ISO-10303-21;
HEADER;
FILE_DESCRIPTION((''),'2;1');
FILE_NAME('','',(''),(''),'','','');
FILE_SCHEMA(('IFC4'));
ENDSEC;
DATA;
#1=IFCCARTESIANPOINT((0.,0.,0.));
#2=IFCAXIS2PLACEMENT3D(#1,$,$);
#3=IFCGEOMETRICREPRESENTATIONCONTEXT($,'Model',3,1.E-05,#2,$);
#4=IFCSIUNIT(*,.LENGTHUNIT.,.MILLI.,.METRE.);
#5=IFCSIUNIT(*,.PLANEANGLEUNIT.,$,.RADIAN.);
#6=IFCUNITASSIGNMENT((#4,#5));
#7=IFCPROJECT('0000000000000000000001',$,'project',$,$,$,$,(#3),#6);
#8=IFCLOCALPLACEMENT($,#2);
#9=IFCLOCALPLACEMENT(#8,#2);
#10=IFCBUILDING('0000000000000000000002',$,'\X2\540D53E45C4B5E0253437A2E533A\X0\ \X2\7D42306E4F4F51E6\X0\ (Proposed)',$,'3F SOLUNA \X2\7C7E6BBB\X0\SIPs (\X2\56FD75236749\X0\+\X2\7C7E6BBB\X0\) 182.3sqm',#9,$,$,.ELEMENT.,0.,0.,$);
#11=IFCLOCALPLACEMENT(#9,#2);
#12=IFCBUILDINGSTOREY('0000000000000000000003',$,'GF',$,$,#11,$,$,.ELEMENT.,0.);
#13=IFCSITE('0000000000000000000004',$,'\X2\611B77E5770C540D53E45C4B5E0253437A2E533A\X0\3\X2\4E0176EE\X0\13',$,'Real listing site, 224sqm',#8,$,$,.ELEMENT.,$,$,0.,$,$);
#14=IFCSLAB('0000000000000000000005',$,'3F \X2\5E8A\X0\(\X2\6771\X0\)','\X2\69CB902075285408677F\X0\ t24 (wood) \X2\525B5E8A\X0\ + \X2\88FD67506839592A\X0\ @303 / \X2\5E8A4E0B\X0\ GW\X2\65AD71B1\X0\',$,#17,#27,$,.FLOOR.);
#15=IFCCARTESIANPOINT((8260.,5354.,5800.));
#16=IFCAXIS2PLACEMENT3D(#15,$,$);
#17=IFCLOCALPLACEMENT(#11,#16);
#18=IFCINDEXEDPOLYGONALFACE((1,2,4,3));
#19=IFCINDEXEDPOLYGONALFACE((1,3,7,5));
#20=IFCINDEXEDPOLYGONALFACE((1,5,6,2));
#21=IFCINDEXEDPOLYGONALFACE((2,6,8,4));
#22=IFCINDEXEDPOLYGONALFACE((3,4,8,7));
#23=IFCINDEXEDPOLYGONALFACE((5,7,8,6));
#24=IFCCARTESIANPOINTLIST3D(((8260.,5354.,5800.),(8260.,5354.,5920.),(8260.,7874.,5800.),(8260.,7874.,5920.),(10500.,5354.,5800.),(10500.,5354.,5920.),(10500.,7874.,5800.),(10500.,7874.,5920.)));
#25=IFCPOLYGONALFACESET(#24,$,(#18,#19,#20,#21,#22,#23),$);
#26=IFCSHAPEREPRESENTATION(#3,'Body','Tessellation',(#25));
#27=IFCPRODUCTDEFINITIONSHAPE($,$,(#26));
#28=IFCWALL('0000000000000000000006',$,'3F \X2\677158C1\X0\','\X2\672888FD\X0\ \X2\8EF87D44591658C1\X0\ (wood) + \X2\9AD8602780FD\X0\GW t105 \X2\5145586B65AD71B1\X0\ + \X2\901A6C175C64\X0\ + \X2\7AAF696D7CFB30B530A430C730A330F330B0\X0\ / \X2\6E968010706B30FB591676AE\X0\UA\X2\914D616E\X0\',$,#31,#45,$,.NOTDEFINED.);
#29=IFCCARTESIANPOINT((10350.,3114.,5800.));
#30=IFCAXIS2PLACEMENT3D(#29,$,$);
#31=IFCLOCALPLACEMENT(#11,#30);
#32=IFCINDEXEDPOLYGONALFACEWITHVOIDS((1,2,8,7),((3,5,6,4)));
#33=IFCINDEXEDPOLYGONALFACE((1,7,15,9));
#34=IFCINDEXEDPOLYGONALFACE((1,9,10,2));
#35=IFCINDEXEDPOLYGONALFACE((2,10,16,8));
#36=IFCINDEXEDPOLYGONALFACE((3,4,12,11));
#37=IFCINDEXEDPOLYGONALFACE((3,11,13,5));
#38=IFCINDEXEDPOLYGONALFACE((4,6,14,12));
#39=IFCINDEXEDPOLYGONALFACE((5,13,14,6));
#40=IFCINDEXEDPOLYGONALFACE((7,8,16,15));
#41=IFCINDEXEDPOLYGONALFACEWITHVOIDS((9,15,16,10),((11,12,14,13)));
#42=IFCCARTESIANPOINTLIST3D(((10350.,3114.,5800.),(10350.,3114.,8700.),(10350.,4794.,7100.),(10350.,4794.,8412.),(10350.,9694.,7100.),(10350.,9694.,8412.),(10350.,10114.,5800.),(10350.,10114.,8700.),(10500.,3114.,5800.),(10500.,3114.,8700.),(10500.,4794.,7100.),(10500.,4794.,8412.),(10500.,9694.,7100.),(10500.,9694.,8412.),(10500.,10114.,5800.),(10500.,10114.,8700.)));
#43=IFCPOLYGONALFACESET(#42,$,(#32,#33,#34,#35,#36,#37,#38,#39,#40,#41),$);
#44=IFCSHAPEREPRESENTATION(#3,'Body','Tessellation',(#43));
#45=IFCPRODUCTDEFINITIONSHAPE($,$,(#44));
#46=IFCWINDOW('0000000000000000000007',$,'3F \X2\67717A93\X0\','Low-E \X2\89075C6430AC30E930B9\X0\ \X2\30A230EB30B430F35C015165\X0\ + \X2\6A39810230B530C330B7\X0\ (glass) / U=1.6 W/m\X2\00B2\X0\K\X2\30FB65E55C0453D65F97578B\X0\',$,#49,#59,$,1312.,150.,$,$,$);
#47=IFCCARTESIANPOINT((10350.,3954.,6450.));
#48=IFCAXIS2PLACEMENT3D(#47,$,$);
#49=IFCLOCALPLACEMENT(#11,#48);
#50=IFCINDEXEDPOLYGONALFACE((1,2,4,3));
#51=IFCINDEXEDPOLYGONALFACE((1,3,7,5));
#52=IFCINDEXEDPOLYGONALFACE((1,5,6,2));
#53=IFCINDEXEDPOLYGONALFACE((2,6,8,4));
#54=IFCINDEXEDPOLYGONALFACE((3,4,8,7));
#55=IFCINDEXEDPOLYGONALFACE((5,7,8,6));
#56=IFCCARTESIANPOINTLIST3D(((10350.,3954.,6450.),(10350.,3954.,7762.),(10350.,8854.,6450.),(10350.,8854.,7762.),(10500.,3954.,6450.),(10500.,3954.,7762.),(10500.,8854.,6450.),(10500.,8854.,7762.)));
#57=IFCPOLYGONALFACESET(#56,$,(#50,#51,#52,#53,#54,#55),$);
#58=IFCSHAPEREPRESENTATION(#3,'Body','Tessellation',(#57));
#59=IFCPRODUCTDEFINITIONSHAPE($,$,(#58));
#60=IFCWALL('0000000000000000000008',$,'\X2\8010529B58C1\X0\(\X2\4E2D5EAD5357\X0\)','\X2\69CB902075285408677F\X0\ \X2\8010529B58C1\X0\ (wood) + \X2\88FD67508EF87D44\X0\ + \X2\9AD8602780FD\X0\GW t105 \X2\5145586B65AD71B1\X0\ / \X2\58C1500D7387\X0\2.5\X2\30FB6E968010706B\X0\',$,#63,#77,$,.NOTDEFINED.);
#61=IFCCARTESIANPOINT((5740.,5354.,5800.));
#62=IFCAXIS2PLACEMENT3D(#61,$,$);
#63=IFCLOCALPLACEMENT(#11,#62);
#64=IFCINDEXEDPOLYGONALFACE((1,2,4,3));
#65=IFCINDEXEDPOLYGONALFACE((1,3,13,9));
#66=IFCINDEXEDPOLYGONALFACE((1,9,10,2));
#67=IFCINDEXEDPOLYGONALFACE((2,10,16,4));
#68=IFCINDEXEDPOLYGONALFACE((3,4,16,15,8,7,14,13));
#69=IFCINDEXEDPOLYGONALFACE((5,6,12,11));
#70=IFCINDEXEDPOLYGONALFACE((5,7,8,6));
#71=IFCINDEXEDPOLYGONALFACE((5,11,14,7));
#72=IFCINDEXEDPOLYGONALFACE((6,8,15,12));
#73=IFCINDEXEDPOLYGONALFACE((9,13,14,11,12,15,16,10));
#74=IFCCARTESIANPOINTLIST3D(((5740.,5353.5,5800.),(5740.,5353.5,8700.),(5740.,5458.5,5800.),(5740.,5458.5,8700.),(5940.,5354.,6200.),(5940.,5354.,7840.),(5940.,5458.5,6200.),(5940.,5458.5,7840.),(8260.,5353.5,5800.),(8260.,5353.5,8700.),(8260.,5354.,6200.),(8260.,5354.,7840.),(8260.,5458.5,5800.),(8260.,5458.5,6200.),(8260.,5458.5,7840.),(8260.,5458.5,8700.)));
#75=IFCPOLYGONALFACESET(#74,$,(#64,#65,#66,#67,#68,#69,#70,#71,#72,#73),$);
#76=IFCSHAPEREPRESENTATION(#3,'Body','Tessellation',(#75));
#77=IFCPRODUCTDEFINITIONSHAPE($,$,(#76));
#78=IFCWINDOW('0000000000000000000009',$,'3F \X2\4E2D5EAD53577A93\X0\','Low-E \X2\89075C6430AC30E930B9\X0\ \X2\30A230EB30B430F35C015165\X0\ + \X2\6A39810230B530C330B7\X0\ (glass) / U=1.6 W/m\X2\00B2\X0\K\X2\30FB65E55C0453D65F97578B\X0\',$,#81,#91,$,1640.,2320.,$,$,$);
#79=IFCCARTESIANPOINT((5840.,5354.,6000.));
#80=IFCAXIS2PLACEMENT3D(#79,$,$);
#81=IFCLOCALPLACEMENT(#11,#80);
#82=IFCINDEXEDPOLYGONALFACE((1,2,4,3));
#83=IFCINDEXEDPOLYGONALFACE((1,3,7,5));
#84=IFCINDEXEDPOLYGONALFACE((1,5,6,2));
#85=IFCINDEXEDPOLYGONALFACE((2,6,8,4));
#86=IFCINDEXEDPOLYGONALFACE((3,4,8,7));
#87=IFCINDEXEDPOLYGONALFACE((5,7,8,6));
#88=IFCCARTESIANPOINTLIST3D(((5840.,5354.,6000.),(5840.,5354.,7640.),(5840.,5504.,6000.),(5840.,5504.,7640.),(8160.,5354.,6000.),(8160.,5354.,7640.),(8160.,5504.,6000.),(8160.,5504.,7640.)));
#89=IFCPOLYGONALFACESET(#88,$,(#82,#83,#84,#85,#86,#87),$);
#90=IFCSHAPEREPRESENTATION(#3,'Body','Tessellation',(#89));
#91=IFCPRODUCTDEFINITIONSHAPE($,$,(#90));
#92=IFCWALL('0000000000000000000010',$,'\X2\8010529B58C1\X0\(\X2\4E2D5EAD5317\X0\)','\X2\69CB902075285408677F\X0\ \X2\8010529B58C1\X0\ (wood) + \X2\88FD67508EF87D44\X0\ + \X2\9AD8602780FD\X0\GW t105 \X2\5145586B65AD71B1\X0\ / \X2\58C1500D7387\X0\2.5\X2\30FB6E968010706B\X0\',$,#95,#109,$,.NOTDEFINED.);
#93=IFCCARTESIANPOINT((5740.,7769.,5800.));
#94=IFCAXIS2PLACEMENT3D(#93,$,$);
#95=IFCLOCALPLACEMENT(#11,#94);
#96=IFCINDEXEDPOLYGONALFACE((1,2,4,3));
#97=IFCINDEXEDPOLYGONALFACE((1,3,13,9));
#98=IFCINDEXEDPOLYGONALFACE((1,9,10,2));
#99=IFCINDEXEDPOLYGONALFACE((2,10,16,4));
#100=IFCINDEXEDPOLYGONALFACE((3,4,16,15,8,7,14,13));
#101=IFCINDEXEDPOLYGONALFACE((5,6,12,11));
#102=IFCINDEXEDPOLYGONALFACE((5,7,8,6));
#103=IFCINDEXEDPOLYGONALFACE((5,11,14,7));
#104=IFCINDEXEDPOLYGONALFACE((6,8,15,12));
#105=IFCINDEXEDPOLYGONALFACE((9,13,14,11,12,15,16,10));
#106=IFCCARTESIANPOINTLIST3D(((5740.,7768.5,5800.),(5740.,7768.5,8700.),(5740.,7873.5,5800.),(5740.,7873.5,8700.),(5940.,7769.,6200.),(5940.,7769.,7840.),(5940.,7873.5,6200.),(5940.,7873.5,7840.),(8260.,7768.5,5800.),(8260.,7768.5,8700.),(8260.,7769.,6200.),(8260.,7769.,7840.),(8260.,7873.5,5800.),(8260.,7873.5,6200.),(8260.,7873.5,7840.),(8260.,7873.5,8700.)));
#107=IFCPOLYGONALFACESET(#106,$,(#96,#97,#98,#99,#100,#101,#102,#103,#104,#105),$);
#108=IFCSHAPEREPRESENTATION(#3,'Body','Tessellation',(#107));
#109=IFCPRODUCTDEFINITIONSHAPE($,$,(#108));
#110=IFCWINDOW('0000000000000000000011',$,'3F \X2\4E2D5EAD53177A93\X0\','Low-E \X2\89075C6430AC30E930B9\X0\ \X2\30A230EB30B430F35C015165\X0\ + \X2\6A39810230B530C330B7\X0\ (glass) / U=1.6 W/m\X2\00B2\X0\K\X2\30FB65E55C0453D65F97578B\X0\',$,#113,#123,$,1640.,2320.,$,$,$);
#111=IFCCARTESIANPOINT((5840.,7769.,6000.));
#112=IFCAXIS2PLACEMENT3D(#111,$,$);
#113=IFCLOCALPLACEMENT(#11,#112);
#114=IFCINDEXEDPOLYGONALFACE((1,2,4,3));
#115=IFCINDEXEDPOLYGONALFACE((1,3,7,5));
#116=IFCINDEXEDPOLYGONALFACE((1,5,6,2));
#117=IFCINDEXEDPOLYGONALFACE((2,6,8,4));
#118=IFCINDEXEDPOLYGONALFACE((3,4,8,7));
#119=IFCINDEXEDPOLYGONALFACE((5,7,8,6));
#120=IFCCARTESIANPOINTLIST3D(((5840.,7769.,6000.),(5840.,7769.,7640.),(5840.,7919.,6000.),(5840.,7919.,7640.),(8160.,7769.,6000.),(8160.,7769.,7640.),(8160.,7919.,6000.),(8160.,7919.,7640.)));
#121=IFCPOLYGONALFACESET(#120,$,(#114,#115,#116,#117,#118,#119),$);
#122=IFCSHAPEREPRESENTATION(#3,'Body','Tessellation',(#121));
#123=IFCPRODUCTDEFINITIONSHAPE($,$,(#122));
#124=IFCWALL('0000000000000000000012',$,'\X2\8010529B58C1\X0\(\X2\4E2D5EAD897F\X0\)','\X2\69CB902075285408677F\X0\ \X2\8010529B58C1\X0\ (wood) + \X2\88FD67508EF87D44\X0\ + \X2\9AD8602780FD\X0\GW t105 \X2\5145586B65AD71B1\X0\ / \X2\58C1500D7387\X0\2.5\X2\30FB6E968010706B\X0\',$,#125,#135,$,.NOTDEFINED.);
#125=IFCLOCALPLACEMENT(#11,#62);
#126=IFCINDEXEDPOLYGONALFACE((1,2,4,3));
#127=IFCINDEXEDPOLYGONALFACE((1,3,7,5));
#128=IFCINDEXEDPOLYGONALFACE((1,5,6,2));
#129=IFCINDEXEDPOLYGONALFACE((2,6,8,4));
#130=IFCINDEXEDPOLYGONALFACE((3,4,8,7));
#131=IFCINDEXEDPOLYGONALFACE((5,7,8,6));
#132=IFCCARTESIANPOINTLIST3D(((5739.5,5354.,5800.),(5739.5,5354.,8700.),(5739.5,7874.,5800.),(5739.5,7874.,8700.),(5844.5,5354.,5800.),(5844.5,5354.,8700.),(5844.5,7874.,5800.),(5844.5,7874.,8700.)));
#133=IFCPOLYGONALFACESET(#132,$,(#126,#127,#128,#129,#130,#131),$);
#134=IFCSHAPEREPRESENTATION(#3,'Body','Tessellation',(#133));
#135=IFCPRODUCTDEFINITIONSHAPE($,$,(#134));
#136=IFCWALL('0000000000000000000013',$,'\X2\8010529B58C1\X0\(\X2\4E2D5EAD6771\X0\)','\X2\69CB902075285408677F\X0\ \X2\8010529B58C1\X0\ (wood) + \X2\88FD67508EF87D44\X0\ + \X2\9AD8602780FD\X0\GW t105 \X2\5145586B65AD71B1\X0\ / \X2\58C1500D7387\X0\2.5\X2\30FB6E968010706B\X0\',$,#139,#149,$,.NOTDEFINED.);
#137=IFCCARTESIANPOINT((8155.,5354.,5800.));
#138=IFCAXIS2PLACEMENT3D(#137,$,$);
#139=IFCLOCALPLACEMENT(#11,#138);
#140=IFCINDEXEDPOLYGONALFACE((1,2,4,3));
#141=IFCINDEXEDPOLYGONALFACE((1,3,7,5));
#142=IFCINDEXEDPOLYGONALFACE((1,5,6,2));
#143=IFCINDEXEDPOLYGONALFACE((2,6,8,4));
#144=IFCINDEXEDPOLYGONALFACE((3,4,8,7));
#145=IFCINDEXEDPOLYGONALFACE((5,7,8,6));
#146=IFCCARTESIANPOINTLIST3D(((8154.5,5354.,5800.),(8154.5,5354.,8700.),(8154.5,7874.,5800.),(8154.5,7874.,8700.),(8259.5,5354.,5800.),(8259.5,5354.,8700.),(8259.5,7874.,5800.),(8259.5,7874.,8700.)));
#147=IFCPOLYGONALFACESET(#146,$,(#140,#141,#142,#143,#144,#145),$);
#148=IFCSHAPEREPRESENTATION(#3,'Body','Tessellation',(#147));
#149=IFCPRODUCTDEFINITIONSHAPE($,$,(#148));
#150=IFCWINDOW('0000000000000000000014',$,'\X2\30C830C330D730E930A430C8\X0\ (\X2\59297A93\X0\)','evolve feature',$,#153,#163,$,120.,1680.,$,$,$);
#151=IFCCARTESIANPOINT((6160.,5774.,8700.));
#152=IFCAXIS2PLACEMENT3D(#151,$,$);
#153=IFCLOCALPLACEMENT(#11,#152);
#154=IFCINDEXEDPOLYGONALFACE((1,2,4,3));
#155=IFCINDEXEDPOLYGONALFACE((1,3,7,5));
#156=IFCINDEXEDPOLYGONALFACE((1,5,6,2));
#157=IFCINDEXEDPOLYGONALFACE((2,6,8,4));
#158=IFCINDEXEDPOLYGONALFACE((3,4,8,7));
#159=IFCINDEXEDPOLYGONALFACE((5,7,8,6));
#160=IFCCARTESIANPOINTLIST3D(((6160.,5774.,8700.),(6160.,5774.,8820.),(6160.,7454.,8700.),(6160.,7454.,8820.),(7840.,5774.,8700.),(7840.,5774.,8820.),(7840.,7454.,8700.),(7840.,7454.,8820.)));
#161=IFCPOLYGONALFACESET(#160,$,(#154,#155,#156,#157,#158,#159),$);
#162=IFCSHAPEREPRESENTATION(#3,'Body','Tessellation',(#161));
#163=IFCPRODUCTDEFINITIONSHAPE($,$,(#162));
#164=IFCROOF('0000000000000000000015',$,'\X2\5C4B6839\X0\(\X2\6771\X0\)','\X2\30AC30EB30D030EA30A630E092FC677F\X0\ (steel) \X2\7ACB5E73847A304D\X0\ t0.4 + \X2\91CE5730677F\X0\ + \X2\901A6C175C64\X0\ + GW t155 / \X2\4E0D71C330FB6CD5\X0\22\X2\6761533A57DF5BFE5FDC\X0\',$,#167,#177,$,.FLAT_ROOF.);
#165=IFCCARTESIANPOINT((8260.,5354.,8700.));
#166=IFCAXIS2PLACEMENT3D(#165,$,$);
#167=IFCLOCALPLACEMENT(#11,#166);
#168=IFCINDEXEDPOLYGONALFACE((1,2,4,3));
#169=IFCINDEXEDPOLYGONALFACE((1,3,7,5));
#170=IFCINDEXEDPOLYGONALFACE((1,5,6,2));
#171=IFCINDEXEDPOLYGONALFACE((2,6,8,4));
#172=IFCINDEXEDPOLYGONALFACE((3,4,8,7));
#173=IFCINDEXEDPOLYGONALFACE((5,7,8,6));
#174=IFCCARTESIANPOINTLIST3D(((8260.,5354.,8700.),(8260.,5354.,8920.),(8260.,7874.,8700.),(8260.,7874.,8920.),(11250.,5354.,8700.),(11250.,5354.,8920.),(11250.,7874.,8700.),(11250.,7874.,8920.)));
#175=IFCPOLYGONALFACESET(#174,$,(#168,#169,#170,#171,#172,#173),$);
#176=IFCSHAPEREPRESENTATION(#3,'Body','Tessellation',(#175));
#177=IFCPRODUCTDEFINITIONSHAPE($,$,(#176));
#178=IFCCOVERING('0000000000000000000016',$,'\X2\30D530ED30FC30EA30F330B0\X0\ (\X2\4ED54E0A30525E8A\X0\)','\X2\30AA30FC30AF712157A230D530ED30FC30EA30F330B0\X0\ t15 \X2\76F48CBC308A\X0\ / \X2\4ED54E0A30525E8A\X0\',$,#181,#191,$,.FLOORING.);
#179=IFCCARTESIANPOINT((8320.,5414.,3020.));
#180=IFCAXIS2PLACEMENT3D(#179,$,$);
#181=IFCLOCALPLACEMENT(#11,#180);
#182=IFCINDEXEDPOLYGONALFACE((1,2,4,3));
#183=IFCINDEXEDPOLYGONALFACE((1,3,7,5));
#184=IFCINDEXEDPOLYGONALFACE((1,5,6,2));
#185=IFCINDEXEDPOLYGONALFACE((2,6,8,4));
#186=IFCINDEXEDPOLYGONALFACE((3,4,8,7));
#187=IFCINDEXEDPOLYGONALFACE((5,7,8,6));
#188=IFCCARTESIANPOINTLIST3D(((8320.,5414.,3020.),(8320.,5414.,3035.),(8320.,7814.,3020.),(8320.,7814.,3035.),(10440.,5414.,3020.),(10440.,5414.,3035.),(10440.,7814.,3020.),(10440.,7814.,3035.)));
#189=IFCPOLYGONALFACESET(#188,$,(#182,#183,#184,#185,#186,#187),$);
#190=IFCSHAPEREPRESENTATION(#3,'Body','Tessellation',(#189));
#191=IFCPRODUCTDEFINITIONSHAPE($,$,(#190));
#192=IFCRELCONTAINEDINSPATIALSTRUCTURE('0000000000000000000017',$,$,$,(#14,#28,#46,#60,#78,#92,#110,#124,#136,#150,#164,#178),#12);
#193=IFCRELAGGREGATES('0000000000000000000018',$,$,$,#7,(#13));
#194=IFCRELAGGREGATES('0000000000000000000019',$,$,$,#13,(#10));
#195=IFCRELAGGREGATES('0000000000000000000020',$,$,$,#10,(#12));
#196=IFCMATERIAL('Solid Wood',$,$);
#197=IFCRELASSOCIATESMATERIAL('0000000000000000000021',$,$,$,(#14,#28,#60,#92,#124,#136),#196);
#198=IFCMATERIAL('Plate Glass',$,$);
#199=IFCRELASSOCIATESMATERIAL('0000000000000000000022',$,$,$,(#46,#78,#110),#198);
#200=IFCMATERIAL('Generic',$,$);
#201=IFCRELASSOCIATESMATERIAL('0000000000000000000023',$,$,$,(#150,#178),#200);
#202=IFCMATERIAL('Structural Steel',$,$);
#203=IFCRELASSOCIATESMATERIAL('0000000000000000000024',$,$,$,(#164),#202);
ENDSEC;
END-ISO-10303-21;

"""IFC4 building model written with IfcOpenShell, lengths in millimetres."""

from ifc_helpers import new_model, si_unit, frame, frame_2d, origin, place, context, project, spatial, rectangle, extrude, material, element, fill, save


model = new_model("IFC4")

# Units and contexts
model_context = context("Model", 3, precision=1e-05, world=origin())
ifc_project = project(units=[si_unit("LENGTHUNIT", "METRE", prefix="MILLI"), si_unit("PLANEANGLEUNIT", "RADIAN")], contexts=[model_context])

# Site, building, storey
site_placement = place(None, origin())
site = spatial("IfcSite", under=ifc_project, at=site_placement, Name="愛知県名古屋市千種区3丁目13", ObjectType="Real listing site, 224sqm", CompositionType="ELEMENT", RefElevation=0.0)
building_placement = place(site_placement, origin())
building = spatial("IfcBuilding", under=site, at=building_placement, Name="名古屋市千種区 終の住処 (Proposed)", ObjectType="3F SOLUNA 籾殻SIPs (国産杉+籾殻) 182.3sqm", CompositionType="ELEMENT", ElevationOfRefHeight=0.0, ElevationOfTerrain=0.0)
storey_placement = place(building_placement, origin())
storey = spatial("IfcBuildingStorey", under=building, at=storey_placement, Name="GF", CompositionType="ELEMENT", Elevation=0.0)

# Slab
ifc_material_1 = material(Name="Solid Wood")
slab_placement = place(storey_placement, frame((8260.0, 5354.0, 5800.0)))
element("IfcSlab", 1, at=slab_placement, inside=storey, material=ifc_material_1, Name="3F 床(東)", Description="構造用合板 t24 (wood) 剛床 + 製材根太 @303 / 床下 GW断熱", PredefinedType="FLOOR", context=model_context, shape_type="SweptSolid", body=[
    extrude(rectangle(XDim=2240.0, YDim=2520.0, at=frame_2d((1120.0, 1260.0))), frame((8260.0, 5354.0, 5800.0)), (0.0, 0.0, 1.0), 120.0),
])

# Walls, openings, windows
wall_1_placement = place(storey_placement, frame((10350.0, 3114.0, 5800.0)))
wall_1 = element("IfcWall", 2, at=wall_1_placement, inside=storey, material=ifc_material_1, Name="3F 東壁", Description="木製 軸組外壁 (wood) + 高性能GW t105 充填断熱 + 通気層 + 窯業系サイディング / 準耐火・外皮UA配慮", PredefinedType="NOTDEFINED", context=model_context, shape_type="SweptSolid", body=[
    extrude(rectangle(XDim=150.0, YDim=7000.0, at=frame_2d((75.0, 3500.0))), frame((10350.0, 3114.0, 5800.0)), (0.0, 0.0, 1.0), 2900.0),
])
opening_1_placement = place(storey_placement, frame((10350.0, 3954.0, 6450.0)))
opening_1 = element("IfcOpeningElement", 3, at=opening_1_placement, cuts=wall_1, PredefinedType="NOTDEFINED", context=model_context, shape_type="SweptSolid", body=[
    extrude(rectangle(XDim=150.0, YDim=4900.0, at=frame_2d((75.0, 2450.0))), frame((10350.0, 3954.0, 6450.0)), (0.0, 0.0, 1.0), 1312.0),
])
ifc_material_2 = material(Name="Plate Glass")
window_1_placement = place(storey_placement, frame((10350.0, 3954.0, 6450.0)))
window_1 = element("IfcWindow", 4, at=window_1_placement, inside=storey, material=ifc_material_2, Name="3F 東窓", Description="Low-E 複層ガラス アルゴン封入 + 樹脂サッシ (glass) / U=1.6 W/m²K・日射取得型", OverallHeight=1312.0, OverallWidth=150.0, context=model_context, shape_type="SweptSolid", body=[
    extrude(rectangle(XDim=150.0, YDim=4900.0, at=frame_2d((75.0, 2450.0))), frame((10350.0, 3954.0, 6450.0)), (0.0, 0.0, 1.0), 1312.0),
])
fill(opening_1, window_1)
wall_2_placement = place(storey_placement, frame((5740.0, 5354.0, 5800.0)))
wall_2 = element("IfcWall", 5, at=wall_2_placement, inside=storey, material=ifc_material_1, Name="耐力壁(中庭南)", Description="構造用合板 耐力壁 (wood) + 製材軸組 + 高性能GW t105 充填断熱 / 壁倍率2.5・準耐火", PredefinedType="NOTDEFINED", context=model_context, shape_type="SweptSolid", body=[
    extrude(rectangle(XDim=2520.0, YDim=105.0, at=frame_2d((1260.0, 52.0))), frame((5740.0, 5354.0, 5800.0)), (0.0, 0.0, 1.0), 2900.0),
])
opening_2_placement = place(storey_placement, frame((5840.0, 5354.0, 6000.0)))
opening_2 = element("IfcOpeningElement", 6, at=opening_2_placement, cuts=wall_2, PredefinedType="NOTDEFINED", context=model_context, shape_type="SweptSolid", body=[
    extrude(rectangle(XDim=2320.0, YDim=150.0, at=frame_2d((1160.0, 75.0))), frame((5840.0, 5354.0, 6000.0)), (0.0, 0.0, 1.0), 1640.0),
])
window_2_placement = place(storey_placement, frame((5840.0, 5354.0, 6000.0)))
window_2 = element("IfcWindow", 7, at=window_2_placement, inside=storey, material=ifc_material_2, Name="3F 中庭南窓", Description="Low-E 複層ガラス アルゴン封入 + 樹脂サッシ (glass) / U=1.6 W/m²K・日射取得型", OverallHeight=1640.0, OverallWidth=2320.0, context=model_context, shape_type="SweptSolid", body=[
    extrude(rectangle(XDim=2320.0, YDim=150.0, at=frame_2d((1160.0, 75.0))), frame((5840.0, 5354.0, 6000.0)), (0.0, 0.0, 1.0), 1640.0),
])
fill(opening_2, window_2)
wall_3_placement = place(storey_placement, frame((5740.0, 7769.0, 5800.0)))
wall_3 = element("IfcWall", 8, at=wall_3_placement, inside=storey, material=ifc_material_1, Name="耐力壁(中庭北)", Description="構造用合板 耐力壁 (wood) + 製材軸組 + 高性能GW t105 充填断熱 / 壁倍率2.5・準耐火", PredefinedType="NOTDEFINED", context=model_context, shape_type="SweptSolid", body=[
    extrude(rectangle(XDim=2520.0, YDim=105.0, at=frame_2d((1260.0, 52.0))), frame((5740.0, 7769.0, 5800.0)), (0.0, 0.0, 1.0), 2900.0),
])
opening_3_placement = place(storey_placement, frame((5840.0, 7769.0, 6000.0)))
opening_3 = element("IfcOpeningElement", 9, at=opening_3_placement, cuts=wall_3, PredefinedType="NOTDEFINED", context=model_context, shape_type="SweptSolid", body=[
    extrude(rectangle(XDim=2320.0, YDim=150.0, at=frame_2d((1160.0, 75.0))), frame((5840.0, 7769.0, 6000.0)), (0.0, 0.0, 1.0), 1640.0),
])
window_3_placement = place(storey_placement, frame((5840.0, 7769.0, 6000.0)))
window_3 = element("IfcWindow", 10, at=window_3_placement, inside=storey, material=ifc_material_2, Name="3F 中庭北窓", Description="Low-E 複層ガラス アルゴン封入 + 樹脂サッシ (glass) / U=1.6 W/m²K・日射取得型", OverallHeight=1640.0, OverallWidth=2320.0, context=model_context, shape_type="SweptSolid", body=[
    extrude(rectangle(XDim=2320.0, YDim=150.0, at=frame_2d((1160.0, 75.0))), frame((5840.0, 7769.0, 6000.0)), (0.0, 0.0, 1.0), 1640.0),
])
fill(opening_3, window_3)

# Walls
wall_4_placement = place(storey_placement, frame((5740.0, 5354.0, 5800.0)))
element("IfcWall", 11, at=wall_4_placement, inside=storey, material=ifc_material_1, Name="耐力壁(中庭西)", Description="構造用合板 耐力壁 (wood) + 製材軸組 + 高性能GW t105 充填断熱 / 壁倍率2.5・準耐火", PredefinedType="NOTDEFINED", context=model_context, shape_type="SweptSolid", body=[
    extrude(rectangle(XDim=105.0, YDim=2520.0, at=frame_2d((52.0, 1260.0))), frame((5740.0, 5354.0, 5800.0)), (0.0, 0.0, 1.0), 2900.0),
])
wall_5_placement = place(storey_placement, frame((8155.0, 5354.0, 5800.0)))
element("IfcWall", 12, at=wall_5_placement, inside=storey, material=ifc_material_1, Name="耐力壁(中庭東)", Description="構造用合板 耐力壁 (wood) + 製材軸組 + 高性能GW t105 充填断熱 / 壁倍率2.5・準耐火", PredefinedType="NOTDEFINED", context=model_context, shape_type="SweptSolid", body=[
    extrude(rectangle(XDim=105.0, YDim=2520.0, at=frame_2d((52.0, 1260.0))), frame((8155.0, 5354.0, 5800.0)), (0.0, 0.0, 1.0), 2900.0),
])

# Window
ifc_material_3 = material(Name="Generic")
window_4_placement = place(storey_placement, frame((6160.0, 5774.0, 8700.0)))
element("IfcWindow", 13, at=window_4_placement, inside=storey, material=ifc_material_3, Name="トップライト (天窓)", Description="evolve feature", OverallHeight=120.0, OverallWidth=1680.0, context=model_context, shape_type="SweptSolid", body=[
    extrude(rectangle(XDim=1680.0, YDim=1680.0, at=frame_2d((840.0, 840.0))), frame((6160.0, 5774.0, 8700.0)), (0.0, 0.0, 1.0), 120.0),
])

# Roof
ifc_material_4 = material(Name="Structural Steel")
for number, where, name in (
    (14, (8260.0, 5354.0, 8700.0), "屋根(東)"),
):
    element("IfcRoof", number, at=place(storey_placement, frame(where)), inside=storey, material=ifc_material_4, Name=name, Description="ガルバリウム鋼板 (steel) 立平葺き t0.4 + 野地板 + 通気層 + GW t155 / 不燃・法22条区域対応", PredefinedType="FLAT_ROOF", context=model_context, shape_type="SweptSolid", body=[
        extrude(rectangle(XDim=2990.0, YDim=2520.0, at=frame_2d((1495.0, 1260.0))), frame((8260.0, 5354.0, 8700.0)), (0.0, 0.0, 1.0), 220.0),
    ])

# Covering
covering_1_placement = place(storey_placement, frame((8320.0, 5414.0, 3020.0)))
element("IfcCovering", 15, at=covering_1_placement, inside=storey, material=ifc_material_3, Name="フローリング (仕上げ床)", Description="オーク無垢フローリング t15 直貼り / 仕上げ床", PredefinedType="FLOORING", context=model_context, shape_type="SweptSolid", body=[
    extrude(rectangle(XDim=2120.0, YDim=2400.0, at=frame_2d((1060.0, 1200.0))), frame((8320.0, 5414.0, 3020.0)), (0.0, 0.0, 1.0), 15.0),
])

save(model, "model.ifc")
